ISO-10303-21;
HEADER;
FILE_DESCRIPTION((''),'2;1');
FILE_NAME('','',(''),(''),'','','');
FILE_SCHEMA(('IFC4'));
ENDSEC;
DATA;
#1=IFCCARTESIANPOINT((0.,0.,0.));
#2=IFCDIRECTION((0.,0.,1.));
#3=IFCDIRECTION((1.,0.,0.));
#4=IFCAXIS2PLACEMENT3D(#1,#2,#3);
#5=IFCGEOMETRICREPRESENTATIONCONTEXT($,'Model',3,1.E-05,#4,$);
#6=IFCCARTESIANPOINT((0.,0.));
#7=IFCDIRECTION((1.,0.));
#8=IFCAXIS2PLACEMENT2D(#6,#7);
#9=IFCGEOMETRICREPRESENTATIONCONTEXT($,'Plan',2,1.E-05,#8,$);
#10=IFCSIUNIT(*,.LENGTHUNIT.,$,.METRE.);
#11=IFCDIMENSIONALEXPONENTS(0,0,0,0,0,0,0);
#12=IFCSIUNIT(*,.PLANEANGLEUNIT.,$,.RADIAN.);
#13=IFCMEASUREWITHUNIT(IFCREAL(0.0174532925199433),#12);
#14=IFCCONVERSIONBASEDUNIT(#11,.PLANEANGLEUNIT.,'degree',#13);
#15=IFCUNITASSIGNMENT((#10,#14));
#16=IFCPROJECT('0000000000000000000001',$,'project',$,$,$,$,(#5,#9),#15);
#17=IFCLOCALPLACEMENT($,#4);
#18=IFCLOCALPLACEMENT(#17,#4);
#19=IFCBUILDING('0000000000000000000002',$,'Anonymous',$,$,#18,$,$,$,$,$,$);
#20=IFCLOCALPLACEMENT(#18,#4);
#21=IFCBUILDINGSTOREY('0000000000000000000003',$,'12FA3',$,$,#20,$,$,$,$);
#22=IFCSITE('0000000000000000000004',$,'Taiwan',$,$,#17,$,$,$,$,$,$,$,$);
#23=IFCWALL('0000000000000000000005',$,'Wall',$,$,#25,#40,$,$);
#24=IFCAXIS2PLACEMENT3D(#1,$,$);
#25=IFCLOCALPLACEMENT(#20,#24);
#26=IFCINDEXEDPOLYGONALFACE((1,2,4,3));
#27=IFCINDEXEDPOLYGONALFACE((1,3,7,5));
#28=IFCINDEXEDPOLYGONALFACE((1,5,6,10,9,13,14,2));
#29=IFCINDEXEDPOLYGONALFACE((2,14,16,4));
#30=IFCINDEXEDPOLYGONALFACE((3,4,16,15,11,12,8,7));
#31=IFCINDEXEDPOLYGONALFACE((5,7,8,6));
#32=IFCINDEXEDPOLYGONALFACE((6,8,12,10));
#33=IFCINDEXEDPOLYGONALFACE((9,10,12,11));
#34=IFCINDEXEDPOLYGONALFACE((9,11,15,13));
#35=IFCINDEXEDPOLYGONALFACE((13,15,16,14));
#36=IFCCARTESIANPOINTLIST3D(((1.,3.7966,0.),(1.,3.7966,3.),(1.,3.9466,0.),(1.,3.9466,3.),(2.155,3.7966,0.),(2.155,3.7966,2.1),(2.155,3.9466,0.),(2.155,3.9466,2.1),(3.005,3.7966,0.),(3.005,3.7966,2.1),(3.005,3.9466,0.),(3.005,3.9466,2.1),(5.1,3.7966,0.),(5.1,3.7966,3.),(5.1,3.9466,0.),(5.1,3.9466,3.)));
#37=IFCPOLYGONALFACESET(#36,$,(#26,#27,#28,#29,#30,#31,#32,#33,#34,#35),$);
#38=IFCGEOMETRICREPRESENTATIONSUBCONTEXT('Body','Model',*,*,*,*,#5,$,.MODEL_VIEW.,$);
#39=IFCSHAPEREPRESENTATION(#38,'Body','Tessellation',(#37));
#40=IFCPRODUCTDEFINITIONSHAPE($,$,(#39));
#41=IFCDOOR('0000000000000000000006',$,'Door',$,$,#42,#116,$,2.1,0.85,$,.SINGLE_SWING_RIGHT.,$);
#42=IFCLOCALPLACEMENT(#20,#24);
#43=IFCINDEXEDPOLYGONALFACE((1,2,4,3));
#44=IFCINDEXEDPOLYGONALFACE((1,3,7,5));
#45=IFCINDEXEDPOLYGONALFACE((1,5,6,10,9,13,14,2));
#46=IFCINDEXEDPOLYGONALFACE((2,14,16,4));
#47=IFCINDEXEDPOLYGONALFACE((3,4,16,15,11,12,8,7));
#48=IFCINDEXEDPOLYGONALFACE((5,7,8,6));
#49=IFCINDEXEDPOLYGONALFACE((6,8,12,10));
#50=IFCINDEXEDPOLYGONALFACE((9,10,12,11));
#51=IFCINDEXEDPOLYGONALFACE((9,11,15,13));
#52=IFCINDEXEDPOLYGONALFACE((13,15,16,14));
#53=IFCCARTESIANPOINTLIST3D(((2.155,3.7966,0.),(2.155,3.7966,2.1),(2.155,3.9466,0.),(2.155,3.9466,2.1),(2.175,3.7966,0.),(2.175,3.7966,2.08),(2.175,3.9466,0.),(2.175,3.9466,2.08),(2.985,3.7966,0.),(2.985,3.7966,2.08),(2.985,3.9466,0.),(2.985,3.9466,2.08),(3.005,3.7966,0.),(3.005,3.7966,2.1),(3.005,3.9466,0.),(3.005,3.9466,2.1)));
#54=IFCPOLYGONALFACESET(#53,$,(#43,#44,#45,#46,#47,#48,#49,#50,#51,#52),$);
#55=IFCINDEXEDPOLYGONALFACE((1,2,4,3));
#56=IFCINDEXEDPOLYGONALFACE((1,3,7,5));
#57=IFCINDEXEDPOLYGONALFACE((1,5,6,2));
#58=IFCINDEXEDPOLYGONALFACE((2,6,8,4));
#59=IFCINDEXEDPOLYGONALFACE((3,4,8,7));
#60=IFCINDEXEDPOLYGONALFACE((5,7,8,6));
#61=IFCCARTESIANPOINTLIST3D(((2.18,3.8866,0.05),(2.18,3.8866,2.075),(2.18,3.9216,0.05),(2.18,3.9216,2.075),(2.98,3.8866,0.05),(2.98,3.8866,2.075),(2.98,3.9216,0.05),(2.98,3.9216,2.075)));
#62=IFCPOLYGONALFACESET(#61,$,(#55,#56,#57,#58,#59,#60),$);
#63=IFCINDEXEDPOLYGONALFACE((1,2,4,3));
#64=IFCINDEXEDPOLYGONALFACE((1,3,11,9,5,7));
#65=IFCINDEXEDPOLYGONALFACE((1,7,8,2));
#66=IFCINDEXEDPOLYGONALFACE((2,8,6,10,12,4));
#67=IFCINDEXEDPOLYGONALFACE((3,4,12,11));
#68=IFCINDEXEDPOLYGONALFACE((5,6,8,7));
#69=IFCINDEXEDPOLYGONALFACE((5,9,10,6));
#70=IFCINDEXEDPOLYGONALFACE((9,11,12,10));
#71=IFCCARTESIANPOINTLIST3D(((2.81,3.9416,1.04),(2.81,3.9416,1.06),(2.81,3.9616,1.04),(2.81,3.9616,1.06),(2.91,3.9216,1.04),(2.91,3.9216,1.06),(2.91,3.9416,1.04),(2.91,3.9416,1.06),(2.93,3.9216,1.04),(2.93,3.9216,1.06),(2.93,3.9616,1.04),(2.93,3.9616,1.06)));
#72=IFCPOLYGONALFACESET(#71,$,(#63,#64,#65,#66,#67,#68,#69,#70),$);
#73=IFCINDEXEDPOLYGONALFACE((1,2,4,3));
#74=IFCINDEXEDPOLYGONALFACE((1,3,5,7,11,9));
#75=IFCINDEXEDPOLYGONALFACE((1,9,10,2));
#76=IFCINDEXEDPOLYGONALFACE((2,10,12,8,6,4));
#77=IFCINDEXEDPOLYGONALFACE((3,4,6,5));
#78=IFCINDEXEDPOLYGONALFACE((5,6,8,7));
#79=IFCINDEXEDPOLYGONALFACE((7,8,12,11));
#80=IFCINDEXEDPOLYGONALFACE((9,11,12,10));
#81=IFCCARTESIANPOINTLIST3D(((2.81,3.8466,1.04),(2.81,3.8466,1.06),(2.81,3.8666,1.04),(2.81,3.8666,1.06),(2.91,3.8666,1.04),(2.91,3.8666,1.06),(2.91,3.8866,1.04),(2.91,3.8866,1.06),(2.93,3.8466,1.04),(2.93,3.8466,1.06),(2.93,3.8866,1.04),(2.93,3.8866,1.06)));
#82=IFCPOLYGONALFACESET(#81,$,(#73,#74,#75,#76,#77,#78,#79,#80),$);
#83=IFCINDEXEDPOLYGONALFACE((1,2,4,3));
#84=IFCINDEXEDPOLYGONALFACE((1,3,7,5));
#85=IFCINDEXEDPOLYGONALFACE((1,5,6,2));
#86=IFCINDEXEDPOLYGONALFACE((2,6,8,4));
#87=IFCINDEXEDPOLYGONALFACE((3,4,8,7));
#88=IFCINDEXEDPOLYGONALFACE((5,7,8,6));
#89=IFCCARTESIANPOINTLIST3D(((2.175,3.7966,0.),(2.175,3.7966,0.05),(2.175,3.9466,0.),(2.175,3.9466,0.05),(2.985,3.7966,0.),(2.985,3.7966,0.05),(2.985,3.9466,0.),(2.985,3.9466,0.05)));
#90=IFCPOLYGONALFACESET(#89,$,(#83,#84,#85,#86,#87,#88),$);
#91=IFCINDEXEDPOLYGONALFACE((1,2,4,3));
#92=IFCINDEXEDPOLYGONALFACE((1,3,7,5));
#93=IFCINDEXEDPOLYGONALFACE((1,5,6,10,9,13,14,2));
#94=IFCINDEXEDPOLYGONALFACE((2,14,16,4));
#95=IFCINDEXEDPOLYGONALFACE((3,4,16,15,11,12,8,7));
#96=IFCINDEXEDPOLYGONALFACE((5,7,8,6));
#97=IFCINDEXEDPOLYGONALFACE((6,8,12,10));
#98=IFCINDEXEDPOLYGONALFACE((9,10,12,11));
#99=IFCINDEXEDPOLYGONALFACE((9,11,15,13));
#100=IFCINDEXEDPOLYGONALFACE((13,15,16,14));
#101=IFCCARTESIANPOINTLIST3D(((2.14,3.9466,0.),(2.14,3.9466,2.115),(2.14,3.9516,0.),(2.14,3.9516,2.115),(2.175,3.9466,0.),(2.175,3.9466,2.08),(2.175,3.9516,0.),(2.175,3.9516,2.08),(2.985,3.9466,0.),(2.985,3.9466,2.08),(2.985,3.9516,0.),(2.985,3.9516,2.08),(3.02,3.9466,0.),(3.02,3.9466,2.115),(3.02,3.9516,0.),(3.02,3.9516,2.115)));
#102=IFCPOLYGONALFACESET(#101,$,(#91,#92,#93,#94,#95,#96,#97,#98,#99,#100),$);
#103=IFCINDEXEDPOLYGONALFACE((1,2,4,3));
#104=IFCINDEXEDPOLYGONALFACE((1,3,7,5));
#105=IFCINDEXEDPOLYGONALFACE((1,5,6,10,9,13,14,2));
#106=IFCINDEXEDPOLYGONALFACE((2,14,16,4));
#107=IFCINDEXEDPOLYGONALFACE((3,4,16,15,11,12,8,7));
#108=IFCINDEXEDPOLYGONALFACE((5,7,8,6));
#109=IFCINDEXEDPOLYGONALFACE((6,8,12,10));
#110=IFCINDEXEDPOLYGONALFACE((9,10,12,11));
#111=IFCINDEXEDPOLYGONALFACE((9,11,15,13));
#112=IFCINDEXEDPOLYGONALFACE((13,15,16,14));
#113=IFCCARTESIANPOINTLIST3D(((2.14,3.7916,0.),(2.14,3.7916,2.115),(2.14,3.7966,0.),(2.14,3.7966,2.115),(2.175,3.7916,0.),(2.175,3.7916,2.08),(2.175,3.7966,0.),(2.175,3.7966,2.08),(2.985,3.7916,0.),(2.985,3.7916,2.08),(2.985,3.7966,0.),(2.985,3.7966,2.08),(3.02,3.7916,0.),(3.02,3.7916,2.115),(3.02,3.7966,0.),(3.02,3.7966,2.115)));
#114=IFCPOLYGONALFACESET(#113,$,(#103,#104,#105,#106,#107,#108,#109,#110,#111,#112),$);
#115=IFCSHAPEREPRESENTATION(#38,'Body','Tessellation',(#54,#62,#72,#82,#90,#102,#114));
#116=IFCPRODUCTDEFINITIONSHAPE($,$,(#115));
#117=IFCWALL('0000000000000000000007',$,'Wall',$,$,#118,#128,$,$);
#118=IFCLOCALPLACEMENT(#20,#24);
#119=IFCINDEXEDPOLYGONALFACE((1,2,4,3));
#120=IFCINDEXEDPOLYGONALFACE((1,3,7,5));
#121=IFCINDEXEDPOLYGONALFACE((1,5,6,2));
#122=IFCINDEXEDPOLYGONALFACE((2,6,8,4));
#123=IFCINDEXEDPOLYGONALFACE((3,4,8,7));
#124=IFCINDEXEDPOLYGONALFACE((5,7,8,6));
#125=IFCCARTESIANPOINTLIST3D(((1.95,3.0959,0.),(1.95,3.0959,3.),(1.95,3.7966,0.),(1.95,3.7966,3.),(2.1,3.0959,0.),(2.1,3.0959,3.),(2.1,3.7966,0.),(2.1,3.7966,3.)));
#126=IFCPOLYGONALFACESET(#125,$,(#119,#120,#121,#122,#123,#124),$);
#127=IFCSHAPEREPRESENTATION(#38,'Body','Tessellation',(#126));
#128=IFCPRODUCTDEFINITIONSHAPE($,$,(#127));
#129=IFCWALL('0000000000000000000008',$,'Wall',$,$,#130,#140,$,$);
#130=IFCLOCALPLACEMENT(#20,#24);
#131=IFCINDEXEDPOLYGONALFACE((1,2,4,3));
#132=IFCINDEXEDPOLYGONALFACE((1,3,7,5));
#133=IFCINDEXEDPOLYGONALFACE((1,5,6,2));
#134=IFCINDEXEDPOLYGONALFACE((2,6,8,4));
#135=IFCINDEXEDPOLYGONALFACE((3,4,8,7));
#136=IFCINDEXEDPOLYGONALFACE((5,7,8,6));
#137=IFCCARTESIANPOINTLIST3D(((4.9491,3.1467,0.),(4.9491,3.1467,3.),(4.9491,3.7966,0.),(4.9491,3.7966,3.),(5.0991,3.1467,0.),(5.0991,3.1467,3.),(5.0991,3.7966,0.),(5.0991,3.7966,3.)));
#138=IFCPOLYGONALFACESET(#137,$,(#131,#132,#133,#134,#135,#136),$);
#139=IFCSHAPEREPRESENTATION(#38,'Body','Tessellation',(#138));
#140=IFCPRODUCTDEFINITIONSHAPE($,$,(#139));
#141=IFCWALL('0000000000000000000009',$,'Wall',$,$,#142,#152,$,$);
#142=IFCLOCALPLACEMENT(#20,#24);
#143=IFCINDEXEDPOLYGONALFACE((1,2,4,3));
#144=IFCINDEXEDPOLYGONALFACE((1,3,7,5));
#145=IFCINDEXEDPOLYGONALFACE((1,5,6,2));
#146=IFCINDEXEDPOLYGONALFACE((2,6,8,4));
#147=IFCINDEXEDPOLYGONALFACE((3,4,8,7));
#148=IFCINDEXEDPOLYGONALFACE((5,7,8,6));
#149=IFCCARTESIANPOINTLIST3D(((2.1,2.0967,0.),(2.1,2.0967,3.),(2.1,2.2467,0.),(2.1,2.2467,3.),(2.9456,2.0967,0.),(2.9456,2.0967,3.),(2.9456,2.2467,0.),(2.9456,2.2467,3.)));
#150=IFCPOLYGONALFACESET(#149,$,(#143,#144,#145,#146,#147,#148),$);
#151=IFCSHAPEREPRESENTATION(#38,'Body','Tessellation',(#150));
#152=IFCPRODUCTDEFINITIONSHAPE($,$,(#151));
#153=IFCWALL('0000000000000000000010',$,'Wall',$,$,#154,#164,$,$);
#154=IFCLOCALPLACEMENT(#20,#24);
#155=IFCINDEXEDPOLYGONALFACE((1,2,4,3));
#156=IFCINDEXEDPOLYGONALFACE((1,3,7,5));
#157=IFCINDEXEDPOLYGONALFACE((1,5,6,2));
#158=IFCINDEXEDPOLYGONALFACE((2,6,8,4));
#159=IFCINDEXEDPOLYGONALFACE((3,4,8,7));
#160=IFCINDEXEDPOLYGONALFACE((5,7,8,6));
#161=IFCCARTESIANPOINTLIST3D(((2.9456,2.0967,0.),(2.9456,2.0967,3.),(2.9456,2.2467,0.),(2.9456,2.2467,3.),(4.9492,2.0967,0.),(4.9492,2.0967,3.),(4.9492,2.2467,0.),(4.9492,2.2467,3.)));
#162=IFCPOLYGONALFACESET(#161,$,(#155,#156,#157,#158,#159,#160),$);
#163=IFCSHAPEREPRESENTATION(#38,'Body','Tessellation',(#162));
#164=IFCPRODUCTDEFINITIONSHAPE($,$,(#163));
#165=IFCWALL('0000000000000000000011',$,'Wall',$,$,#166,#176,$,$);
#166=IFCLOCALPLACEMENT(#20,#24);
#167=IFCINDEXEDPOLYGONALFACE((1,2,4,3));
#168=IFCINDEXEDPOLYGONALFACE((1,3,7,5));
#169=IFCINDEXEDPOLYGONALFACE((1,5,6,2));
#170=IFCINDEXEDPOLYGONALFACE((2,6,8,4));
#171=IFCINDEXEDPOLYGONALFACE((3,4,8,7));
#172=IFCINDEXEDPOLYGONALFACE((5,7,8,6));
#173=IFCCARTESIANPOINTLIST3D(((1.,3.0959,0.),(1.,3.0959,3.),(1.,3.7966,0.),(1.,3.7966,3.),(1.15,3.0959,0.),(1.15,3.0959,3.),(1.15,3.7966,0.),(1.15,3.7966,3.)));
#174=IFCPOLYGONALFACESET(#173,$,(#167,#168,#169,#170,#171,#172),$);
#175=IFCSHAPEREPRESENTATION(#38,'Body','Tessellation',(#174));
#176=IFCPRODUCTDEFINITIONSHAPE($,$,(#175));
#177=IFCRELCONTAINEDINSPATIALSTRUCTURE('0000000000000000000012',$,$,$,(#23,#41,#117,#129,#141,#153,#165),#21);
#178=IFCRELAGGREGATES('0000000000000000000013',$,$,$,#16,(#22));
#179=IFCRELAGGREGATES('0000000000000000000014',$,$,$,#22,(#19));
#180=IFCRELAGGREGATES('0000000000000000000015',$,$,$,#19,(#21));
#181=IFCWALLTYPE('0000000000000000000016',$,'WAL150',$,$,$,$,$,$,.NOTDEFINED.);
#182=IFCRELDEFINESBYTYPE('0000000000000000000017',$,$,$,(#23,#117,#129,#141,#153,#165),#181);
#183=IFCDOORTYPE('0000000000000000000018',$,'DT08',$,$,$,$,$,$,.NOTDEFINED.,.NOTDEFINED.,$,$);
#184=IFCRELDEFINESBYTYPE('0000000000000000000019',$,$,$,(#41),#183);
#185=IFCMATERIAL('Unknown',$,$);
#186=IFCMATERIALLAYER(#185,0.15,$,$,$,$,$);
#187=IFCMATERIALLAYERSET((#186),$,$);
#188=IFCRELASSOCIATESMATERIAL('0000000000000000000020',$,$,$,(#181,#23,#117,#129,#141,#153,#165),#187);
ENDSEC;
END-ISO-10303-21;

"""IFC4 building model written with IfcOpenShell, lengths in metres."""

from ifc_helpers import new_model, entity, si_unit, converted_unit, frame, origin_with_axes, origin_2d_with_axis, place, context, subcontext, project, spatial, line, indexed_curve, outline, extrude, shape, source, transform, mapped, material, layer, layer_set, layer_usage, type_object, type_shapes, element, fill, save


model = new_model("IFC4")

# Units and contexts
model_context = context("Model", 3, precision=1e-05, world=origin_with_axes())
plan_context = context("Plan", 2, precision=1e-05, world=origin_2d_with_axis())
body_context_1 = subcontext(model_context, "Body", "Model", "MODEL_VIEW")
body_context_2 = subcontext(plan_context, "Body", "Plan", "PLAN_VIEW")
ifc_project = project(units=[si_unit("LENGTHUNIT", "METRE"), converted_unit("PLANEANGLEUNIT", "degree", entity("IfcReal", 0.0174532925199433), si_unit("PLANEANGLEUNIT", "RADIAN"), dimensions=[0, 0, 0, 0, 0, 0, 0])], contexts=[model_context, plan_context])

# Site, building, storey
site_placement = place(None, origin_with_axes())
site = spatial("IfcSite", under=ifc_project, at=site_placement, Name="Taiwan")
building_placement = place(site_placement, origin_with_axes())
building = spatial("IfcBuilding", under=site, at=building_placement, Name="Anonymous")
storey_placement = place(building_placement, origin_with_axes())
storey = spatial("IfcBuildingStorey", under=building, at=storey_placement, Name="12FA3")

# Shared definitions
ifc_material = material(Name="Unknown")

# Wall, opening, door
ifc_layer_1 = layer(ifc_material, 0.15)
ifc_layer_set_1 = layer_set([ifc_layer_1])
ifc_layer_usage_1 = layer_usage(ifc_layer_set_1, "AXIS2", "POSITIVE", 0.0)
wall_type_1 = type_object("IfcWallType", Name="WAL150", PredefinedType="NOTDEFINED", material=ifc_layer_set_1)
wall_1_placement = place(storey_placement, frame((1.0, 3.7966, 0.0), z_axis=(0.0, 0.0, 1.0), x_axis=(1.0, 0.0, 0.0)))
wall_1 = element("IfcWall", 1, at=wall_1_placement, inside=storey, type_object=wall_type_1, material=ifc_layer_usage_1, Name="Wall", context=body_context_1, shape_type="SweptSolid", body=[
    extrude(outline(indexed_curve([(0.0, 0.0), (0.0, 0.15), (4.1, 0.15), (4.1, 0.0)], segments=[line(1, 2, 3, 4, 1)])), origin_with_axes(), (0.0, 0.0, 1.0), 3.0),
])
shared_shape_1 = source(origin_with_axes(), body_context_1, "Body", "SweptSolid", [
    extrude(outline(indexed_curve([(0.0, 0.0), (0.85, 0.0), (0.85, 2.1), (0.0, 2.1)], segments=[line(1, 2, 3, 4, 1)])), frame((0.0, -0.6, 0.0), z_axis=(0.0, -1.0, 0.0), x_axis=(1.0, 0.0, 0.0)), (0.0, 0.0, -1.0), 1.2),
])
opening_1_placement = place(wall_1_placement, frame((2.005, 0.15, 0.0), z_axis=(0.0, 0.0, 1.0), x_axis=(-1.0, 0.0, 0.0)))
opening_1 = element("IfcOpeningElement", 2, at=opening_1_placement, cuts=wall_1, PredefinedType="OPENING", context=body_context_1, shape_type="MappedRepresentation", body=[
    mapped(shared_shape_1, transform((0.0, 0.0, 0.0), x_axis=(1.0, 0.0, 0.0), y_axis=(0.0, 1.0, 0.0), z_axis=(0.0, 0.0, 1.0), scale=1.0)),
])
door_type_1 = type_object("IfcDoorType", Name="DT08", OperationType="NOTDEFINED", PredefinedType="NOTDEFINED")
shared_shape_2 = source(origin_with_axes(), body_context_1, "Body", "SweptSolid", [
    extrude(outline(indexed_curve([(0.0, 0.0), (0.0, 2.1), (0.85, 2.1), (0.85, 0.0), (0.83, 0.0), (0.83, 2.08), (0.02, 2.08), (0.02, 0.0)], segments=[line(1, 2, 3, 4, 5, 6, 7, 8, 1)])), frame((0.0, 0.0, 0.0), z_axis=(0.0, -1.0, 0.0), x_axis=(1.0, 0.0, 0.0)), (0.0, 0.0, -1.0), 0.15),
    extrude(outline(indexed_curve([(0.0, 0.0), (0.8, 0.0), (0.8, 0.035), (0.0, 0.035)], segments=[line(1, 2, 3, 4, 1)])), frame((0.025, 0.025, 0.05), z_axis=(0.0, 0.0, 1.0), x_axis=(1.0, 0.0, 0.0)), (0.0, 0.0, 1.0), 2.025),
    extrude(outline(indexed_curve([(0.0, 0.0), (0.0, -0.04), (0.12, -0.04), (0.12, -0.02), (0.02, -0.02), (0.02, 0.0)], segments=[line(1, 2, 3, 4, 5, 6, 1)])), frame((0.075, 0.025, 1.04), z_axis=(0.0, 0.0, 1.0), x_axis=(1.0, 0.0, 0.0)), (0.0, 0.0, 1.0), 0.02),
    extrude(outline(indexed_curve([(0.0, 0.0), (0.0, 0.04), (0.12, 0.04), (0.12, 0.02), (0.02, 0.02), (0.02, 0.0)], segments=[line(1, 2, 3, 4, 5, 6, 1)])), frame((0.075, 0.06, 1.04), z_axis=(0.0, 0.0, 1.0), x_axis=(1.0, 0.0, 0.0)), (0.0, 0.0, 1.0), 0.02),
    extrude(outline(indexed_curve([(0.0, 0.0), (0.81, 0.0), (0.81, 0.15), (0.0, 0.15)], segments=[line(1, 2, 3, 4, 1)])), frame((0.02, 0.0, 0.0), z_axis=(0.0, 0.0, 1.0), x_axis=(1.0, 0.0, 0.0)), (0.0, 0.0, 1.0), 0.05),
    extrude(outline(indexed_curve([(0.0, 0.0), (0.0, 2.115), (0.88, 2.115), (0.88, 0.0), (0.845, 0.0), (0.845, 2.08), (0.035, 2.08), (0.035, 0.0)], segments=[line(1, 2, 3, 4, 5, 6, 7, 8, 1)])), frame((-0.015, -0.005, 0.0), z_axis=(0.0, -1.0, 0.0), x_axis=(1.0, 0.0, 0.0)), (0.0, 0.0, -1.0), 0.005),
    extrude(outline(indexed_curve([(0.0, 0.0), (0.0, 2.115), (0.88, 2.115), (0.88, 0.0), (0.845, 0.0), (0.845, 2.08), (0.035, 2.08), (0.035, 0.0)], segments=[line(1, 2, 3, 4, 5, 6, 7, 8, 1)])), frame((-0.015, 0.15, 0.0), z_axis=(0.0, -1.0, 0.0), x_axis=(1.0, 0.0, 0.0)), (0.0, 0.0, -1.0), 0.005),
])
shared_shape_3 = source(origin_with_axes(), body_context_2, "Body", "Curve2D", [
    entity("IfcIndexedPolyCurve", entity("IfcCartesianPointList2D", [[0.0, 0.0], [0.02, 0.0], [0.02, 0.15], [0.0, 0.15]]), [entity("IfcLineIndex", [1, 2, 3, 4, 1])]),
    entity("IfcIndexedPolyCurve", entity("IfcCartesianPointList2D", [[0.85, 0.0], [0.83, 0.0], [0.83, 0.15], [0.85, 0.15]]), [entity("IfcLineIndex", [1, 2, 3, 4, 1])]),
    entity("IfcTrimmedCurve", entity("IfcEllipse", entity("IfcAxis2Placement2D", entity("IfcCartesianPoint", [0.79, 0.15]), entity("IfcDirection", [1.0, 0.0])), 0.765, 0.8), [entity("IfcCartesianPoint", [0.79, 0.95])], [entity("IfcCartesianPoint", [0.025, 0.15])], True, "CARTESIAN"),
    entity("IfcIndexedPolyCurve", entity("IfcCartesianPointList2D", [[0.825, 0.15], [0.79, 0.15], [0.79, 0.95], [0.825, 0.95]]), [entity("IfcLineIndex", [1, 2, 3, 4, 1])]),
])
type_shapes(door_type_1, [shared_shape_2, shared_shape_3])
door_1_placement = place(opening_1_placement, origin_with_axes())
door_1 = element("IfcDoor", 3, at=door_1_placement, inside=storey, type_object=door_type_1, Name="Door", OperationType="SINGLE_SWING_RIGHT", OverallHeight=2.1, OverallWidth=0.85, shapes=[
    shape(body_context_1, "Body", "MappedRepresentation", [mapped(shared_shape_2, transform((0.0, 0.0, 0.0), x_axis=(1.0, 0.0, 0.0), y_axis=(0.0, 1.0, 0.0), z_axis=(0.0, 0.0, 1.0), scale=1.0))]),
    shape(body_context_2, "Body", "MappedRepresentation", [mapped(shared_shape_3, transform((0.0, 0.0, 0.0), x_axis=(1.0, 0.0, 0.0), y_axis=(0.0, 1.0, 0.0), z_axis=(0.0, 0.0, 1.0), scale=1.0))]),
])
fill(opening_1, door_1)

# Walls
ifc_layer_usage_2 = layer_usage(ifc_layer_set_1, "AXIS2", "POSITIVE", 0.0)
wall_2_placement = place(storey_placement, frame((1.95, 3.7966, 0.0), z_axis=(0.0, 0.0, 1.0), x_axis=(0.0, -1.0, 0.0)))
element("IfcWall", 4, at=wall_2_placement, inside=storey, type_object=wall_type_1, material=ifc_layer_usage_2, Name="Wall", context=body_context_1, shape_type="SweptSolid", body=[
    extrude(outline(indexed_curve([(0.0, 0.0), (0.0, 0.15), (0.7007, 0.15), (0.7007, 0.0)], segments=[line(1, 2, 3, 4, 1)])), origin_with_axes(), (0.0, 0.0, 1.0), 3.0),
])
ifc_layer_usage_3 = layer_usage(ifc_layer_set_1, "AXIS2", "POSITIVE", 0.0)
wall_3_placement = place(storey_placement, frame((4.9491, 3.7966, 0.0), z_axis=(0.0, 0.0, 1.0), x_axis=(0.0, -1.0, 0.0)))
element("IfcWall", 5, at=wall_3_placement, inside=storey, type_object=wall_type_1, material=ifc_layer_usage_3, Name="Wall", context=body_context_1, shape_type="SweptSolid", body=[
    extrude(outline(indexed_curve([(0.0, 0.0), (0.0, 0.15), (0.6499, 0.15), (0.6499, 0.0)], segments=[line(1, 2, 3, 4, 1)])), origin_with_axes(), (0.0, 0.0, 1.0), 3.0),
])
ifc_layer_usage_4 = layer_usage(ifc_layer_set_1, "AXIS2", "POSITIVE", 0.0)
wall_4_placement = place(storey_placement, frame((2.1, 2.0967, 0.0), z_axis=(0.0, 0.0, 1.0), x_axis=(1.0, 0.0, 0.0)))
element("IfcWall", 6, at=wall_4_placement, inside=storey, type_object=wall_type_1, material=ifc_layer_usage_4, Name="Wall", context=body_context_1, shape_type="SweptSolid", body=[
    extrude(outline(indexed_curve([(0.0, 0.0), (0.0, 0.15), (0.8456, 0.15), (0.8456, 0.0)], segments=[line(1, 2, 3, 4, 1)])), origin_with_axes(), (0.0, 0.0, 1.0), 3.0),
])
ifc_layer_usage_5 = layer_usage(ifc_layer_set_1, "AXIS2", "POSITIVE", 0.0)
wall_5_placement = place(storey_placement, frame((2.9456, 2.0967, 0.0), z_axis=(0.0, 0.0, 1.0), x_axis=(1.0, 0.0, 0.0)))
element("IfcWall", 7, at=wall_5_placement, inside=storey, type_object=wall_type_1, material=ifc_layer_usage_5, Name="Wall", context=body_context_1, shape_type="SweptSolid", body=[
    extrude(outline(indexed_curve([(0.0, 0.0), (0.0, 0.15), (2.0037, 0.15), (2.0037, 0.0)], segments=[line(1, 2, 3, 4, 1)])), origin_with_axes(), (0.0, 0.0, 1.0), 3.0),
])
ifc_layer_usage_6 = layer_usage(ifc_layer_set_1, "AXIS2", "POSITIVE", 0.0)
wall_6_placement = place(storey_placement, frame((1.0, 3.7966, 0.0), z_axis=(0.0, 0.0, 1.0), x_axis=(0.0, -1.0, 0.0)))
element("IfcWall", 8, at=wall_6_placement, inside=storey, type_object=wall_type_1, material=ifc_layer_usage_6, Name="Wall", context=body_context_1, shape_type="SweptSolid", body=[
    extrude(outline(indexed_curve([(0.0, 0.0), (0.0, 0.15), (0.7007, 0.15), (0.7007, 0.0)], segments=[line(1, 2, 3, 4, 1)])), origin_with_axes(), (0.0, 0.0, 1.0), 3.0),
])

save(model, "model.ifc")
